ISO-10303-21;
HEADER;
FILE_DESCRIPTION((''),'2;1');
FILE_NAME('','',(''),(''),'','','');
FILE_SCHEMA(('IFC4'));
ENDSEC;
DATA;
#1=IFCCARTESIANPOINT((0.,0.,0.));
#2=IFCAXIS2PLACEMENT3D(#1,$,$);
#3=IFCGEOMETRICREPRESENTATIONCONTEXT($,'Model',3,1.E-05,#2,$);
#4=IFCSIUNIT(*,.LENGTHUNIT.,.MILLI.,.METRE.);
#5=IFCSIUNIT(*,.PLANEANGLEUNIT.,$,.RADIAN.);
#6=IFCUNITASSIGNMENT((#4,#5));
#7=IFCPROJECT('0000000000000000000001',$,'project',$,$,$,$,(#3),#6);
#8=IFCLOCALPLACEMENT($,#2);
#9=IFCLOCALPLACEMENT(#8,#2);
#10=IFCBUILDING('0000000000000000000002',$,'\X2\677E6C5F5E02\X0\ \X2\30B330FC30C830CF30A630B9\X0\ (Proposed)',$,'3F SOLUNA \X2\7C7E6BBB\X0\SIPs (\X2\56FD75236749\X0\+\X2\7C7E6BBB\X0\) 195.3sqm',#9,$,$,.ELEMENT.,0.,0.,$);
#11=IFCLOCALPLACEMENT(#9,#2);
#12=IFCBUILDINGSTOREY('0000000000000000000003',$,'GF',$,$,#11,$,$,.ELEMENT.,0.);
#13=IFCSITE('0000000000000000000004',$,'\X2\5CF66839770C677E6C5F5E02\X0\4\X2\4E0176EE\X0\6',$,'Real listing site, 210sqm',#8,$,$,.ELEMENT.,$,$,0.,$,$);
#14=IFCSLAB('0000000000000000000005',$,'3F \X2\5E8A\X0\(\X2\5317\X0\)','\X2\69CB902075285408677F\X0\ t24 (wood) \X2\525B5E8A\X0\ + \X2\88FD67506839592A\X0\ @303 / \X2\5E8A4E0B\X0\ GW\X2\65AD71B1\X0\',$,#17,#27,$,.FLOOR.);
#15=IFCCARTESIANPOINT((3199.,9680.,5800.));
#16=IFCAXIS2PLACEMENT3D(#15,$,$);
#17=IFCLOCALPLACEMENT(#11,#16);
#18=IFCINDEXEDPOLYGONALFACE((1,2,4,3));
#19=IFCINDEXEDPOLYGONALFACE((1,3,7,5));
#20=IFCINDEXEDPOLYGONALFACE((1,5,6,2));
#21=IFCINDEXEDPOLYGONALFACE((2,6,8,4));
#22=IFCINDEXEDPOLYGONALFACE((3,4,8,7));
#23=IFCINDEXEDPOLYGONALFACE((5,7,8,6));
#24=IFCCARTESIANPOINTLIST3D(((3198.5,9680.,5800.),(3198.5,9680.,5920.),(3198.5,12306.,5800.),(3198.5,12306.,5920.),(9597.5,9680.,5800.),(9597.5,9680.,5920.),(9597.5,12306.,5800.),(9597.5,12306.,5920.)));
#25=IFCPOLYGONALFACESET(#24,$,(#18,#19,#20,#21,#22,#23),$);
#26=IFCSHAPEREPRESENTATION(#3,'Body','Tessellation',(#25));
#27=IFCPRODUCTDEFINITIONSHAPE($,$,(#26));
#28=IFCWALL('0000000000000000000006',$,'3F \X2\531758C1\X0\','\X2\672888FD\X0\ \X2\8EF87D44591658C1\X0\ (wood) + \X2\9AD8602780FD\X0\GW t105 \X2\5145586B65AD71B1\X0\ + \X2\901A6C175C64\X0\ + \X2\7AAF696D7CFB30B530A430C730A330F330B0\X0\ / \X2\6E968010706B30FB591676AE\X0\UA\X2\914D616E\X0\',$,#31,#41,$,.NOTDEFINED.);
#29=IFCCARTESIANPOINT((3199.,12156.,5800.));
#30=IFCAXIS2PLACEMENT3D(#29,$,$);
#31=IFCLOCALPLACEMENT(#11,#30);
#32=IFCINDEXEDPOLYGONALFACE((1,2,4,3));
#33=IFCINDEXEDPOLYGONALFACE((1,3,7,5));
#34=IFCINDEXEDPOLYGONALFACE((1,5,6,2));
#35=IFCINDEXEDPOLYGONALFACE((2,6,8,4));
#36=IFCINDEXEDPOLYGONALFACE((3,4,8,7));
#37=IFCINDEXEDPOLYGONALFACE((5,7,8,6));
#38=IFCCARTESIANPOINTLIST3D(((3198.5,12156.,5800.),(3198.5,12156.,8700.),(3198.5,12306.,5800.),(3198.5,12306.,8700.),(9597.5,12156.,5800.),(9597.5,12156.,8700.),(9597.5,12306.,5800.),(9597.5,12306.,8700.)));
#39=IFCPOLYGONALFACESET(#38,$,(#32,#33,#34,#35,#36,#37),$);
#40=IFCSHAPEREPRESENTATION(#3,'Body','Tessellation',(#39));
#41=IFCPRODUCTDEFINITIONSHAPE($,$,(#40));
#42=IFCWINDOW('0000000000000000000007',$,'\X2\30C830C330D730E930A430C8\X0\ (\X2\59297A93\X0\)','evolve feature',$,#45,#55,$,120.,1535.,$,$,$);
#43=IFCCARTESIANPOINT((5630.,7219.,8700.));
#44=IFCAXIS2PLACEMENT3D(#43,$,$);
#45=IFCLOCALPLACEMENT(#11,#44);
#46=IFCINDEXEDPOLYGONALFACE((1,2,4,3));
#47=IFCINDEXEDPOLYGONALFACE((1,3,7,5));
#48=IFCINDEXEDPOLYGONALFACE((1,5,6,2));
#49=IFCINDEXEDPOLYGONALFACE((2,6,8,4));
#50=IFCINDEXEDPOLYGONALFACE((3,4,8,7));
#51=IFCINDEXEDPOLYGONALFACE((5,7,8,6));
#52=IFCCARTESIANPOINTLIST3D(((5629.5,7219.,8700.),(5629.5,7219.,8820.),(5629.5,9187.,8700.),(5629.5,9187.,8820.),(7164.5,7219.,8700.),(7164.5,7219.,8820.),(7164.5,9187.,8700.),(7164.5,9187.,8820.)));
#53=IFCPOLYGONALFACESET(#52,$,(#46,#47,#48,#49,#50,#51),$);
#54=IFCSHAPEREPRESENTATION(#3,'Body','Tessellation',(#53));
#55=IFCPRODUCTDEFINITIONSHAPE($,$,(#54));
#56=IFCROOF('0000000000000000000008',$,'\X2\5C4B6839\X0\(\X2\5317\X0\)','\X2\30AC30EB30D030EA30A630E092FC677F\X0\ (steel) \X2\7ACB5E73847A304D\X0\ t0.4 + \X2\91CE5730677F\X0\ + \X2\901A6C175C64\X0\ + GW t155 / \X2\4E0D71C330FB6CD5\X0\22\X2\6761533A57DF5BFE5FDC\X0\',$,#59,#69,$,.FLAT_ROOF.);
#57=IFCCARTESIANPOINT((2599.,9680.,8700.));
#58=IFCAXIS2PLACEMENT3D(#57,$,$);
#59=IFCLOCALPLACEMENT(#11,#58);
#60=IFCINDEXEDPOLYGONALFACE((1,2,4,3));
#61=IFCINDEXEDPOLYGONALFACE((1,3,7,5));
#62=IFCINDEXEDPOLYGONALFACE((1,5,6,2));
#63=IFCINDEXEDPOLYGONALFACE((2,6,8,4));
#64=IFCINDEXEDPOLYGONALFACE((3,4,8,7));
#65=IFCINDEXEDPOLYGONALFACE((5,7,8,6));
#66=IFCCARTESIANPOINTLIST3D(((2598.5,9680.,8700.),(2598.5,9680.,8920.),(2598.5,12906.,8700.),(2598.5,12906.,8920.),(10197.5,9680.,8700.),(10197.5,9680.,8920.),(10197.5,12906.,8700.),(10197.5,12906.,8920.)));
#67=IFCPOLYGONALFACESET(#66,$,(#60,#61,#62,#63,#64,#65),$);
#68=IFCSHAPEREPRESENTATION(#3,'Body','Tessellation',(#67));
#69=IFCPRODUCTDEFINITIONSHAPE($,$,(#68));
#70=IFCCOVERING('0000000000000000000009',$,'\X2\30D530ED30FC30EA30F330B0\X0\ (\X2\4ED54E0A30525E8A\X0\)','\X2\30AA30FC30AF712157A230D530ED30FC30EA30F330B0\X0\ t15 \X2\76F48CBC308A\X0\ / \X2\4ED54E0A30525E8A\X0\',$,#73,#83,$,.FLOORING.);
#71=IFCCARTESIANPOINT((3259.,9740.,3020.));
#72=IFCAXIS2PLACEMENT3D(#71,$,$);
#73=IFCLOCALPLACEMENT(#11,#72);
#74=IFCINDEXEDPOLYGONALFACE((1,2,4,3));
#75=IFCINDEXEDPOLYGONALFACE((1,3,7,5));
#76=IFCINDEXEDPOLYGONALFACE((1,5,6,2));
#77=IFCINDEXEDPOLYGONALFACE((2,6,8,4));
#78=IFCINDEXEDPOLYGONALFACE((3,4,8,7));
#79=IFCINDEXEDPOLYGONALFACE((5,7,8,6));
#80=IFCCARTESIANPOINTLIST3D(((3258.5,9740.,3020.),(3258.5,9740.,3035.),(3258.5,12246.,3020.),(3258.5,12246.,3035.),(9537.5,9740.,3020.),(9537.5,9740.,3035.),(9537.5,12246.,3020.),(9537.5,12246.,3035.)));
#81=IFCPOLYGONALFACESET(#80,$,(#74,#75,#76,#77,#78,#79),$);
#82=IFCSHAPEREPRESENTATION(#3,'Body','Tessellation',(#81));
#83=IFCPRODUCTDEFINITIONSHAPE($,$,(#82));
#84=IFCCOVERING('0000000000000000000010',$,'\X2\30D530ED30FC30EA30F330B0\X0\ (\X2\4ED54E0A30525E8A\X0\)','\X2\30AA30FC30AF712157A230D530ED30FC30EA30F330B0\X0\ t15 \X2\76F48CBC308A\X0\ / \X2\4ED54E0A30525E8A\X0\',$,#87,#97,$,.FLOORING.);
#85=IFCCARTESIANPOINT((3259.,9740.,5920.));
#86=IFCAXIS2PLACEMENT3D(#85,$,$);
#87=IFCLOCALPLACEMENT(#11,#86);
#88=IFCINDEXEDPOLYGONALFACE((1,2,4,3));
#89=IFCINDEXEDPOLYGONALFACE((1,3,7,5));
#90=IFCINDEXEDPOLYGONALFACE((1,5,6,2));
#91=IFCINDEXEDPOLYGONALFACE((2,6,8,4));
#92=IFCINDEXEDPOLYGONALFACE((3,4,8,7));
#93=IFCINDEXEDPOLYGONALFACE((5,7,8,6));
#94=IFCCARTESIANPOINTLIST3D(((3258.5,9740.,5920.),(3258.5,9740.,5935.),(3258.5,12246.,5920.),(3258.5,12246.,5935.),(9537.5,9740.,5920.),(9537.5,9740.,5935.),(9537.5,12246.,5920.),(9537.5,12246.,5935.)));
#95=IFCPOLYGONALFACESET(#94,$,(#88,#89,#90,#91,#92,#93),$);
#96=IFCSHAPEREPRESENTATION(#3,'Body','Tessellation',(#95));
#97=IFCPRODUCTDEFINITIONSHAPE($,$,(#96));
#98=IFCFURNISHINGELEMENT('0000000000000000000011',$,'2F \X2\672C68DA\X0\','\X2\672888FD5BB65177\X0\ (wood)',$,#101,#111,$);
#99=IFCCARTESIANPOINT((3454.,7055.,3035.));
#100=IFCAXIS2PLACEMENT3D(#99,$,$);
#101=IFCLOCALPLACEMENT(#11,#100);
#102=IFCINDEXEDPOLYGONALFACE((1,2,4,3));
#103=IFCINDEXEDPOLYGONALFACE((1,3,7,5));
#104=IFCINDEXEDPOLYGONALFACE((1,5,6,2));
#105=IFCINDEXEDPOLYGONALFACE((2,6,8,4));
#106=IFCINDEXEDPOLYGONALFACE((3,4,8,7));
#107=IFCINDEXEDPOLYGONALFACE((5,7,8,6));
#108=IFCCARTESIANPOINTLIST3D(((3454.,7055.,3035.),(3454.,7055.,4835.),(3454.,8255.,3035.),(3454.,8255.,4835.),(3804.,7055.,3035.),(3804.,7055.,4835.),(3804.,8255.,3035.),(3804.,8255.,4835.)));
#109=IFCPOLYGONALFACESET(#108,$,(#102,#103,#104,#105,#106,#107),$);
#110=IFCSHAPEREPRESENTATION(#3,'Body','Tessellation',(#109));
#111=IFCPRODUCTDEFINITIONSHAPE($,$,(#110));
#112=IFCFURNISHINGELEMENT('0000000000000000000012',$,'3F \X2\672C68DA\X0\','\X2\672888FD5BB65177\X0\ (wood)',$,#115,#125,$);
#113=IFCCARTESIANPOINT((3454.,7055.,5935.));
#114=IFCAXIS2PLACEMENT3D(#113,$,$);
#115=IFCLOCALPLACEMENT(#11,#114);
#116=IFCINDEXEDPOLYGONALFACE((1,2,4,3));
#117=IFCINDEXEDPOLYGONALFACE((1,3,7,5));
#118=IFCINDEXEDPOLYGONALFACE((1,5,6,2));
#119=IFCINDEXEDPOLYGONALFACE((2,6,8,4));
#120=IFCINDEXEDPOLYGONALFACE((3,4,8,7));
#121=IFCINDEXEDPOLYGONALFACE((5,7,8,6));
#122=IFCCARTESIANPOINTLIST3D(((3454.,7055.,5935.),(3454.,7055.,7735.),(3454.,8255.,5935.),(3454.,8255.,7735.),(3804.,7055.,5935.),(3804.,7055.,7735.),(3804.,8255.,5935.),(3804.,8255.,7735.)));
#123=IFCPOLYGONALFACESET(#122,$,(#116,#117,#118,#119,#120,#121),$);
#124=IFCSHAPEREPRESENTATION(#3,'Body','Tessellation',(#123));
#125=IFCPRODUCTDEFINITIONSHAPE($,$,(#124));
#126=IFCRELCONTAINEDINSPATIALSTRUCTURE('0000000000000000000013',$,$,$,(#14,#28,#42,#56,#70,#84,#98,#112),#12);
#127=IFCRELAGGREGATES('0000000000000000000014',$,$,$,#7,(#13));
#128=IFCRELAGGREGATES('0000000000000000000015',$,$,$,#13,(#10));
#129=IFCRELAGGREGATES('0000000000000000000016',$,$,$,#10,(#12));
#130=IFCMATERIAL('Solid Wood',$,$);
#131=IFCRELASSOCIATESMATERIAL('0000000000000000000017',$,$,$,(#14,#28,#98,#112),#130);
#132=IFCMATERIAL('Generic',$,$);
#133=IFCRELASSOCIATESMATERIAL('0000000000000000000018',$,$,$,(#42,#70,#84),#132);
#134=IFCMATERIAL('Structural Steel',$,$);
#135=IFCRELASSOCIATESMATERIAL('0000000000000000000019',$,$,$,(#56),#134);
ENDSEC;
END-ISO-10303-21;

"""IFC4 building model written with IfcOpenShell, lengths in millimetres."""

from ifc_helpers import new_model, si_unit, frame, frame_2d, origin, place, context, project, spatial, rectangle, extrude, material, element, save


model = new_model("IFC4")

# Units and contexts
model_context = context("Model", 3, precision=1e-05, world=origin())
ifc_project = project(units=[si_unit("LENGTHUNIT", "METRE", prefix="MILLI"), si_unit("PLANEANGLEUNIT", "RADIAN")], contexts=[model_context])

# Site, building, storey
site_placement = place(None, origin())
site = spatial("IfcSite", under=ifc_project, at=site_placement, Name="島根県松江市4丁目6", ObjectType="Real listing site, 210sqm", CompositionType="ELEMENT", RefElevation=0.0)
building_placement = place(site_placement, origin())
building = spatial("IfcBuilding", under=site, at=building_placement, Name="松江市 コートハウス (Proposed)", ObjectType="3F SOLUNA 籾殻SIPs (国産杉+籾殻) 195.3sqm", CompositionType="ELEMENT", ElevationOfRefHeight=0.0, ElevationOfTerrain=0.0)
storey_placement = place(building_placement, origin())
storey = spatial("IfcBuildingStorey", under=building, at=storey_placement, Name="GF", CompositionType="ELEMENT", Elevation=0.0)

# Slab
ifc_material_1 = material(Name="Solid Wood")
slab_placement = place(storey_placement, frame((3199.0, 9680.0, 5800.0)))
element("IfcSlab", 1, at=slab_placement, inside=storey, material=ifc_material_1, Name="3F 床(北)", Description="構造用合板 t24 (wood) 剛床 + 製材根太 @303 / 床下 GW断熱", PredefinedType="FLOOR", context=model_context, shape_type="SweptSolid", body=[
    extrude(rectangle(XDim=6399.0, YDim=2626.0, at=frame_2d((3199.0, 1313.0))), frame((3199.0, 9680.0, 5800.0)), (0.0, 0.0, 1.0), 120.0),
])

# Wall
wall_1_placement = place(storey_placement, frame((3199.0, 12156.0, 5800.0)))
element("IfcWall", 2, at=wall_1_placement, inside=storey, material=ifc_material_1, Name="3F 北壁", Description="木製 軸組外壁 (wood) + 高性能GW t105 充填断熱 + 通気層 + 窯業系サイディング / 準耐火・外皮UA配慮", PredefinedType="NOTDEFINED", context=model_context, shape_type="SweptSolid", body=[
    extrude(rectangle(XDim=6399.0, YDim=150.0, at=frame_2d((3199.0, 75.0))), frame((3199.0, 12156.0, 5800.0)), (0.0, 0.0, 1.0), 2900.0),
])

# Window
ifc_material_2 = material(Name="Generic")
window_1_placement = place(storey_placement, frame((5630.0, 7219.0, 8700.0)))
element("IfcWindow", 3, at=window_1_placement, inside=storey, material=ifc_material_2, Name="トップライト (天窓)", Description="evolve feature", OverallHeight=120.0, OverallWidth=1535.0, context=model_context, shape_type="SweptSolid", body=[
    extrude(rectangle(XDim=1535.0, YDim=1968.0, at=frame_2d((767.0, 984.0))), frame((5630.0, 7219.0, 8700.0)), (0.0, 0.0, 1.0), 120.0),
])

# Roof
ifc_material_3 = material(Name="Structural Steel")
roof_1_placement = place(storey_placement, frame((2599.0, 9680.0, 8700.0)))
element("IfcRoof", 4, at=roof_1_placement, inside=storey, material=ifc_material_3, Name="屋根(北)", Description="ガルバリウム鋼板 (steel) 立平葺き t0.4 + 野地板 + 通気層 + GW t155 / 不燃・法22条区域対応", PredefinedType="FLAT_ROOF", context=model_context, shape_type="SweptSolid", body=[
    extrude(rectangle(XDim=7599.0, YDim=3226.0, at=frame_2d((3799.0, 1613.0))), frame((2599.0, 9680.0, 8700.0)), (0.0, 0.0, 1.0), 220.0),
])

# Coverings
covering_1_placement = place(storey_placement, frame((3259.0, 9740.0, 3020.0)))
element("IfcCovering", 5, at=covering_1_placement, inside=storey, material=ifc_material_2, Name="フローリング (仕上げ床)", Description="オーク無垢フローリング t15 直貼り / 仕上げ床", PredefinedType="FLOORING", context=model_context, shape_type="SweptSolid", body=[
    extrude(rectangle(XDim=6279.0, YDim=2506.0, at=frame_2d((3139.0, 1253.0))), frame((3259.0, 9740.0, 3020.0)), (0.0, 0.0, 1.0), 15.0),
])
covering_2_placement = place(storey_placement, frame((3259.0, 9740.0, 5920.0)))
element("IfcCovering", 6, at=covering_2_placement, inside=storey, material=ifc_material_2, Name="フローリング (仕上げ床)", Description="オーク無垢フローリング t15 直貼り / 仕上げ床", PredefinedType="FLOORING", context=model_context, shape_type="SweptSolid", body=[
    extrude(rectangle(XDim=6279.0, YDim=2506.0, at=frame_2d((3139.0, 1253.0))), frame((3259.0, 9740.0, 5920.0)), (0.0, 0.0, 1.0), 15.0),
])

# Furnishing elements
furnishing_1_placement = place(storey_placement, frame((3454.0, 7055.0, 3035.0)))
element("IfcFurnishingElement", 7, at=furnishing_1_placement, inside=storey, material=ifc_material_1, Name="2F 本棚", Description="木製家具 (wood)", context=model_context, shape_type="SweptSolid", body=[
    extrude(rectangle(XDim=350.0, YDim=1200.0, at=frame_2d((175.0, 600.0))), frame((3454.0, 7055.0, 3035.0)), (0.0, 0.0, 1.0), 1800.0),
])
furnishing_2_placement = place(storey_placement, frame((3454.0, 7055.0, 5935.0)))
element("IfcFurnishingElement", 8, at=furnishing_2_placement, inside=storey, material=ifc_material_1, Name="3F 本棚", Description="木製家具 (wood)", context=model_context, shape_type="SweptSolid", body=[
    extrude(rectangle(XDim=350.0, YDim=1200.0, at=frame_2d((175.0, 600.0))), frame((3454.0, 7055.0, 5935.0)), (0.0, 0.0, 1.0), 1800.0),
])

save(model, "model.ifc")
